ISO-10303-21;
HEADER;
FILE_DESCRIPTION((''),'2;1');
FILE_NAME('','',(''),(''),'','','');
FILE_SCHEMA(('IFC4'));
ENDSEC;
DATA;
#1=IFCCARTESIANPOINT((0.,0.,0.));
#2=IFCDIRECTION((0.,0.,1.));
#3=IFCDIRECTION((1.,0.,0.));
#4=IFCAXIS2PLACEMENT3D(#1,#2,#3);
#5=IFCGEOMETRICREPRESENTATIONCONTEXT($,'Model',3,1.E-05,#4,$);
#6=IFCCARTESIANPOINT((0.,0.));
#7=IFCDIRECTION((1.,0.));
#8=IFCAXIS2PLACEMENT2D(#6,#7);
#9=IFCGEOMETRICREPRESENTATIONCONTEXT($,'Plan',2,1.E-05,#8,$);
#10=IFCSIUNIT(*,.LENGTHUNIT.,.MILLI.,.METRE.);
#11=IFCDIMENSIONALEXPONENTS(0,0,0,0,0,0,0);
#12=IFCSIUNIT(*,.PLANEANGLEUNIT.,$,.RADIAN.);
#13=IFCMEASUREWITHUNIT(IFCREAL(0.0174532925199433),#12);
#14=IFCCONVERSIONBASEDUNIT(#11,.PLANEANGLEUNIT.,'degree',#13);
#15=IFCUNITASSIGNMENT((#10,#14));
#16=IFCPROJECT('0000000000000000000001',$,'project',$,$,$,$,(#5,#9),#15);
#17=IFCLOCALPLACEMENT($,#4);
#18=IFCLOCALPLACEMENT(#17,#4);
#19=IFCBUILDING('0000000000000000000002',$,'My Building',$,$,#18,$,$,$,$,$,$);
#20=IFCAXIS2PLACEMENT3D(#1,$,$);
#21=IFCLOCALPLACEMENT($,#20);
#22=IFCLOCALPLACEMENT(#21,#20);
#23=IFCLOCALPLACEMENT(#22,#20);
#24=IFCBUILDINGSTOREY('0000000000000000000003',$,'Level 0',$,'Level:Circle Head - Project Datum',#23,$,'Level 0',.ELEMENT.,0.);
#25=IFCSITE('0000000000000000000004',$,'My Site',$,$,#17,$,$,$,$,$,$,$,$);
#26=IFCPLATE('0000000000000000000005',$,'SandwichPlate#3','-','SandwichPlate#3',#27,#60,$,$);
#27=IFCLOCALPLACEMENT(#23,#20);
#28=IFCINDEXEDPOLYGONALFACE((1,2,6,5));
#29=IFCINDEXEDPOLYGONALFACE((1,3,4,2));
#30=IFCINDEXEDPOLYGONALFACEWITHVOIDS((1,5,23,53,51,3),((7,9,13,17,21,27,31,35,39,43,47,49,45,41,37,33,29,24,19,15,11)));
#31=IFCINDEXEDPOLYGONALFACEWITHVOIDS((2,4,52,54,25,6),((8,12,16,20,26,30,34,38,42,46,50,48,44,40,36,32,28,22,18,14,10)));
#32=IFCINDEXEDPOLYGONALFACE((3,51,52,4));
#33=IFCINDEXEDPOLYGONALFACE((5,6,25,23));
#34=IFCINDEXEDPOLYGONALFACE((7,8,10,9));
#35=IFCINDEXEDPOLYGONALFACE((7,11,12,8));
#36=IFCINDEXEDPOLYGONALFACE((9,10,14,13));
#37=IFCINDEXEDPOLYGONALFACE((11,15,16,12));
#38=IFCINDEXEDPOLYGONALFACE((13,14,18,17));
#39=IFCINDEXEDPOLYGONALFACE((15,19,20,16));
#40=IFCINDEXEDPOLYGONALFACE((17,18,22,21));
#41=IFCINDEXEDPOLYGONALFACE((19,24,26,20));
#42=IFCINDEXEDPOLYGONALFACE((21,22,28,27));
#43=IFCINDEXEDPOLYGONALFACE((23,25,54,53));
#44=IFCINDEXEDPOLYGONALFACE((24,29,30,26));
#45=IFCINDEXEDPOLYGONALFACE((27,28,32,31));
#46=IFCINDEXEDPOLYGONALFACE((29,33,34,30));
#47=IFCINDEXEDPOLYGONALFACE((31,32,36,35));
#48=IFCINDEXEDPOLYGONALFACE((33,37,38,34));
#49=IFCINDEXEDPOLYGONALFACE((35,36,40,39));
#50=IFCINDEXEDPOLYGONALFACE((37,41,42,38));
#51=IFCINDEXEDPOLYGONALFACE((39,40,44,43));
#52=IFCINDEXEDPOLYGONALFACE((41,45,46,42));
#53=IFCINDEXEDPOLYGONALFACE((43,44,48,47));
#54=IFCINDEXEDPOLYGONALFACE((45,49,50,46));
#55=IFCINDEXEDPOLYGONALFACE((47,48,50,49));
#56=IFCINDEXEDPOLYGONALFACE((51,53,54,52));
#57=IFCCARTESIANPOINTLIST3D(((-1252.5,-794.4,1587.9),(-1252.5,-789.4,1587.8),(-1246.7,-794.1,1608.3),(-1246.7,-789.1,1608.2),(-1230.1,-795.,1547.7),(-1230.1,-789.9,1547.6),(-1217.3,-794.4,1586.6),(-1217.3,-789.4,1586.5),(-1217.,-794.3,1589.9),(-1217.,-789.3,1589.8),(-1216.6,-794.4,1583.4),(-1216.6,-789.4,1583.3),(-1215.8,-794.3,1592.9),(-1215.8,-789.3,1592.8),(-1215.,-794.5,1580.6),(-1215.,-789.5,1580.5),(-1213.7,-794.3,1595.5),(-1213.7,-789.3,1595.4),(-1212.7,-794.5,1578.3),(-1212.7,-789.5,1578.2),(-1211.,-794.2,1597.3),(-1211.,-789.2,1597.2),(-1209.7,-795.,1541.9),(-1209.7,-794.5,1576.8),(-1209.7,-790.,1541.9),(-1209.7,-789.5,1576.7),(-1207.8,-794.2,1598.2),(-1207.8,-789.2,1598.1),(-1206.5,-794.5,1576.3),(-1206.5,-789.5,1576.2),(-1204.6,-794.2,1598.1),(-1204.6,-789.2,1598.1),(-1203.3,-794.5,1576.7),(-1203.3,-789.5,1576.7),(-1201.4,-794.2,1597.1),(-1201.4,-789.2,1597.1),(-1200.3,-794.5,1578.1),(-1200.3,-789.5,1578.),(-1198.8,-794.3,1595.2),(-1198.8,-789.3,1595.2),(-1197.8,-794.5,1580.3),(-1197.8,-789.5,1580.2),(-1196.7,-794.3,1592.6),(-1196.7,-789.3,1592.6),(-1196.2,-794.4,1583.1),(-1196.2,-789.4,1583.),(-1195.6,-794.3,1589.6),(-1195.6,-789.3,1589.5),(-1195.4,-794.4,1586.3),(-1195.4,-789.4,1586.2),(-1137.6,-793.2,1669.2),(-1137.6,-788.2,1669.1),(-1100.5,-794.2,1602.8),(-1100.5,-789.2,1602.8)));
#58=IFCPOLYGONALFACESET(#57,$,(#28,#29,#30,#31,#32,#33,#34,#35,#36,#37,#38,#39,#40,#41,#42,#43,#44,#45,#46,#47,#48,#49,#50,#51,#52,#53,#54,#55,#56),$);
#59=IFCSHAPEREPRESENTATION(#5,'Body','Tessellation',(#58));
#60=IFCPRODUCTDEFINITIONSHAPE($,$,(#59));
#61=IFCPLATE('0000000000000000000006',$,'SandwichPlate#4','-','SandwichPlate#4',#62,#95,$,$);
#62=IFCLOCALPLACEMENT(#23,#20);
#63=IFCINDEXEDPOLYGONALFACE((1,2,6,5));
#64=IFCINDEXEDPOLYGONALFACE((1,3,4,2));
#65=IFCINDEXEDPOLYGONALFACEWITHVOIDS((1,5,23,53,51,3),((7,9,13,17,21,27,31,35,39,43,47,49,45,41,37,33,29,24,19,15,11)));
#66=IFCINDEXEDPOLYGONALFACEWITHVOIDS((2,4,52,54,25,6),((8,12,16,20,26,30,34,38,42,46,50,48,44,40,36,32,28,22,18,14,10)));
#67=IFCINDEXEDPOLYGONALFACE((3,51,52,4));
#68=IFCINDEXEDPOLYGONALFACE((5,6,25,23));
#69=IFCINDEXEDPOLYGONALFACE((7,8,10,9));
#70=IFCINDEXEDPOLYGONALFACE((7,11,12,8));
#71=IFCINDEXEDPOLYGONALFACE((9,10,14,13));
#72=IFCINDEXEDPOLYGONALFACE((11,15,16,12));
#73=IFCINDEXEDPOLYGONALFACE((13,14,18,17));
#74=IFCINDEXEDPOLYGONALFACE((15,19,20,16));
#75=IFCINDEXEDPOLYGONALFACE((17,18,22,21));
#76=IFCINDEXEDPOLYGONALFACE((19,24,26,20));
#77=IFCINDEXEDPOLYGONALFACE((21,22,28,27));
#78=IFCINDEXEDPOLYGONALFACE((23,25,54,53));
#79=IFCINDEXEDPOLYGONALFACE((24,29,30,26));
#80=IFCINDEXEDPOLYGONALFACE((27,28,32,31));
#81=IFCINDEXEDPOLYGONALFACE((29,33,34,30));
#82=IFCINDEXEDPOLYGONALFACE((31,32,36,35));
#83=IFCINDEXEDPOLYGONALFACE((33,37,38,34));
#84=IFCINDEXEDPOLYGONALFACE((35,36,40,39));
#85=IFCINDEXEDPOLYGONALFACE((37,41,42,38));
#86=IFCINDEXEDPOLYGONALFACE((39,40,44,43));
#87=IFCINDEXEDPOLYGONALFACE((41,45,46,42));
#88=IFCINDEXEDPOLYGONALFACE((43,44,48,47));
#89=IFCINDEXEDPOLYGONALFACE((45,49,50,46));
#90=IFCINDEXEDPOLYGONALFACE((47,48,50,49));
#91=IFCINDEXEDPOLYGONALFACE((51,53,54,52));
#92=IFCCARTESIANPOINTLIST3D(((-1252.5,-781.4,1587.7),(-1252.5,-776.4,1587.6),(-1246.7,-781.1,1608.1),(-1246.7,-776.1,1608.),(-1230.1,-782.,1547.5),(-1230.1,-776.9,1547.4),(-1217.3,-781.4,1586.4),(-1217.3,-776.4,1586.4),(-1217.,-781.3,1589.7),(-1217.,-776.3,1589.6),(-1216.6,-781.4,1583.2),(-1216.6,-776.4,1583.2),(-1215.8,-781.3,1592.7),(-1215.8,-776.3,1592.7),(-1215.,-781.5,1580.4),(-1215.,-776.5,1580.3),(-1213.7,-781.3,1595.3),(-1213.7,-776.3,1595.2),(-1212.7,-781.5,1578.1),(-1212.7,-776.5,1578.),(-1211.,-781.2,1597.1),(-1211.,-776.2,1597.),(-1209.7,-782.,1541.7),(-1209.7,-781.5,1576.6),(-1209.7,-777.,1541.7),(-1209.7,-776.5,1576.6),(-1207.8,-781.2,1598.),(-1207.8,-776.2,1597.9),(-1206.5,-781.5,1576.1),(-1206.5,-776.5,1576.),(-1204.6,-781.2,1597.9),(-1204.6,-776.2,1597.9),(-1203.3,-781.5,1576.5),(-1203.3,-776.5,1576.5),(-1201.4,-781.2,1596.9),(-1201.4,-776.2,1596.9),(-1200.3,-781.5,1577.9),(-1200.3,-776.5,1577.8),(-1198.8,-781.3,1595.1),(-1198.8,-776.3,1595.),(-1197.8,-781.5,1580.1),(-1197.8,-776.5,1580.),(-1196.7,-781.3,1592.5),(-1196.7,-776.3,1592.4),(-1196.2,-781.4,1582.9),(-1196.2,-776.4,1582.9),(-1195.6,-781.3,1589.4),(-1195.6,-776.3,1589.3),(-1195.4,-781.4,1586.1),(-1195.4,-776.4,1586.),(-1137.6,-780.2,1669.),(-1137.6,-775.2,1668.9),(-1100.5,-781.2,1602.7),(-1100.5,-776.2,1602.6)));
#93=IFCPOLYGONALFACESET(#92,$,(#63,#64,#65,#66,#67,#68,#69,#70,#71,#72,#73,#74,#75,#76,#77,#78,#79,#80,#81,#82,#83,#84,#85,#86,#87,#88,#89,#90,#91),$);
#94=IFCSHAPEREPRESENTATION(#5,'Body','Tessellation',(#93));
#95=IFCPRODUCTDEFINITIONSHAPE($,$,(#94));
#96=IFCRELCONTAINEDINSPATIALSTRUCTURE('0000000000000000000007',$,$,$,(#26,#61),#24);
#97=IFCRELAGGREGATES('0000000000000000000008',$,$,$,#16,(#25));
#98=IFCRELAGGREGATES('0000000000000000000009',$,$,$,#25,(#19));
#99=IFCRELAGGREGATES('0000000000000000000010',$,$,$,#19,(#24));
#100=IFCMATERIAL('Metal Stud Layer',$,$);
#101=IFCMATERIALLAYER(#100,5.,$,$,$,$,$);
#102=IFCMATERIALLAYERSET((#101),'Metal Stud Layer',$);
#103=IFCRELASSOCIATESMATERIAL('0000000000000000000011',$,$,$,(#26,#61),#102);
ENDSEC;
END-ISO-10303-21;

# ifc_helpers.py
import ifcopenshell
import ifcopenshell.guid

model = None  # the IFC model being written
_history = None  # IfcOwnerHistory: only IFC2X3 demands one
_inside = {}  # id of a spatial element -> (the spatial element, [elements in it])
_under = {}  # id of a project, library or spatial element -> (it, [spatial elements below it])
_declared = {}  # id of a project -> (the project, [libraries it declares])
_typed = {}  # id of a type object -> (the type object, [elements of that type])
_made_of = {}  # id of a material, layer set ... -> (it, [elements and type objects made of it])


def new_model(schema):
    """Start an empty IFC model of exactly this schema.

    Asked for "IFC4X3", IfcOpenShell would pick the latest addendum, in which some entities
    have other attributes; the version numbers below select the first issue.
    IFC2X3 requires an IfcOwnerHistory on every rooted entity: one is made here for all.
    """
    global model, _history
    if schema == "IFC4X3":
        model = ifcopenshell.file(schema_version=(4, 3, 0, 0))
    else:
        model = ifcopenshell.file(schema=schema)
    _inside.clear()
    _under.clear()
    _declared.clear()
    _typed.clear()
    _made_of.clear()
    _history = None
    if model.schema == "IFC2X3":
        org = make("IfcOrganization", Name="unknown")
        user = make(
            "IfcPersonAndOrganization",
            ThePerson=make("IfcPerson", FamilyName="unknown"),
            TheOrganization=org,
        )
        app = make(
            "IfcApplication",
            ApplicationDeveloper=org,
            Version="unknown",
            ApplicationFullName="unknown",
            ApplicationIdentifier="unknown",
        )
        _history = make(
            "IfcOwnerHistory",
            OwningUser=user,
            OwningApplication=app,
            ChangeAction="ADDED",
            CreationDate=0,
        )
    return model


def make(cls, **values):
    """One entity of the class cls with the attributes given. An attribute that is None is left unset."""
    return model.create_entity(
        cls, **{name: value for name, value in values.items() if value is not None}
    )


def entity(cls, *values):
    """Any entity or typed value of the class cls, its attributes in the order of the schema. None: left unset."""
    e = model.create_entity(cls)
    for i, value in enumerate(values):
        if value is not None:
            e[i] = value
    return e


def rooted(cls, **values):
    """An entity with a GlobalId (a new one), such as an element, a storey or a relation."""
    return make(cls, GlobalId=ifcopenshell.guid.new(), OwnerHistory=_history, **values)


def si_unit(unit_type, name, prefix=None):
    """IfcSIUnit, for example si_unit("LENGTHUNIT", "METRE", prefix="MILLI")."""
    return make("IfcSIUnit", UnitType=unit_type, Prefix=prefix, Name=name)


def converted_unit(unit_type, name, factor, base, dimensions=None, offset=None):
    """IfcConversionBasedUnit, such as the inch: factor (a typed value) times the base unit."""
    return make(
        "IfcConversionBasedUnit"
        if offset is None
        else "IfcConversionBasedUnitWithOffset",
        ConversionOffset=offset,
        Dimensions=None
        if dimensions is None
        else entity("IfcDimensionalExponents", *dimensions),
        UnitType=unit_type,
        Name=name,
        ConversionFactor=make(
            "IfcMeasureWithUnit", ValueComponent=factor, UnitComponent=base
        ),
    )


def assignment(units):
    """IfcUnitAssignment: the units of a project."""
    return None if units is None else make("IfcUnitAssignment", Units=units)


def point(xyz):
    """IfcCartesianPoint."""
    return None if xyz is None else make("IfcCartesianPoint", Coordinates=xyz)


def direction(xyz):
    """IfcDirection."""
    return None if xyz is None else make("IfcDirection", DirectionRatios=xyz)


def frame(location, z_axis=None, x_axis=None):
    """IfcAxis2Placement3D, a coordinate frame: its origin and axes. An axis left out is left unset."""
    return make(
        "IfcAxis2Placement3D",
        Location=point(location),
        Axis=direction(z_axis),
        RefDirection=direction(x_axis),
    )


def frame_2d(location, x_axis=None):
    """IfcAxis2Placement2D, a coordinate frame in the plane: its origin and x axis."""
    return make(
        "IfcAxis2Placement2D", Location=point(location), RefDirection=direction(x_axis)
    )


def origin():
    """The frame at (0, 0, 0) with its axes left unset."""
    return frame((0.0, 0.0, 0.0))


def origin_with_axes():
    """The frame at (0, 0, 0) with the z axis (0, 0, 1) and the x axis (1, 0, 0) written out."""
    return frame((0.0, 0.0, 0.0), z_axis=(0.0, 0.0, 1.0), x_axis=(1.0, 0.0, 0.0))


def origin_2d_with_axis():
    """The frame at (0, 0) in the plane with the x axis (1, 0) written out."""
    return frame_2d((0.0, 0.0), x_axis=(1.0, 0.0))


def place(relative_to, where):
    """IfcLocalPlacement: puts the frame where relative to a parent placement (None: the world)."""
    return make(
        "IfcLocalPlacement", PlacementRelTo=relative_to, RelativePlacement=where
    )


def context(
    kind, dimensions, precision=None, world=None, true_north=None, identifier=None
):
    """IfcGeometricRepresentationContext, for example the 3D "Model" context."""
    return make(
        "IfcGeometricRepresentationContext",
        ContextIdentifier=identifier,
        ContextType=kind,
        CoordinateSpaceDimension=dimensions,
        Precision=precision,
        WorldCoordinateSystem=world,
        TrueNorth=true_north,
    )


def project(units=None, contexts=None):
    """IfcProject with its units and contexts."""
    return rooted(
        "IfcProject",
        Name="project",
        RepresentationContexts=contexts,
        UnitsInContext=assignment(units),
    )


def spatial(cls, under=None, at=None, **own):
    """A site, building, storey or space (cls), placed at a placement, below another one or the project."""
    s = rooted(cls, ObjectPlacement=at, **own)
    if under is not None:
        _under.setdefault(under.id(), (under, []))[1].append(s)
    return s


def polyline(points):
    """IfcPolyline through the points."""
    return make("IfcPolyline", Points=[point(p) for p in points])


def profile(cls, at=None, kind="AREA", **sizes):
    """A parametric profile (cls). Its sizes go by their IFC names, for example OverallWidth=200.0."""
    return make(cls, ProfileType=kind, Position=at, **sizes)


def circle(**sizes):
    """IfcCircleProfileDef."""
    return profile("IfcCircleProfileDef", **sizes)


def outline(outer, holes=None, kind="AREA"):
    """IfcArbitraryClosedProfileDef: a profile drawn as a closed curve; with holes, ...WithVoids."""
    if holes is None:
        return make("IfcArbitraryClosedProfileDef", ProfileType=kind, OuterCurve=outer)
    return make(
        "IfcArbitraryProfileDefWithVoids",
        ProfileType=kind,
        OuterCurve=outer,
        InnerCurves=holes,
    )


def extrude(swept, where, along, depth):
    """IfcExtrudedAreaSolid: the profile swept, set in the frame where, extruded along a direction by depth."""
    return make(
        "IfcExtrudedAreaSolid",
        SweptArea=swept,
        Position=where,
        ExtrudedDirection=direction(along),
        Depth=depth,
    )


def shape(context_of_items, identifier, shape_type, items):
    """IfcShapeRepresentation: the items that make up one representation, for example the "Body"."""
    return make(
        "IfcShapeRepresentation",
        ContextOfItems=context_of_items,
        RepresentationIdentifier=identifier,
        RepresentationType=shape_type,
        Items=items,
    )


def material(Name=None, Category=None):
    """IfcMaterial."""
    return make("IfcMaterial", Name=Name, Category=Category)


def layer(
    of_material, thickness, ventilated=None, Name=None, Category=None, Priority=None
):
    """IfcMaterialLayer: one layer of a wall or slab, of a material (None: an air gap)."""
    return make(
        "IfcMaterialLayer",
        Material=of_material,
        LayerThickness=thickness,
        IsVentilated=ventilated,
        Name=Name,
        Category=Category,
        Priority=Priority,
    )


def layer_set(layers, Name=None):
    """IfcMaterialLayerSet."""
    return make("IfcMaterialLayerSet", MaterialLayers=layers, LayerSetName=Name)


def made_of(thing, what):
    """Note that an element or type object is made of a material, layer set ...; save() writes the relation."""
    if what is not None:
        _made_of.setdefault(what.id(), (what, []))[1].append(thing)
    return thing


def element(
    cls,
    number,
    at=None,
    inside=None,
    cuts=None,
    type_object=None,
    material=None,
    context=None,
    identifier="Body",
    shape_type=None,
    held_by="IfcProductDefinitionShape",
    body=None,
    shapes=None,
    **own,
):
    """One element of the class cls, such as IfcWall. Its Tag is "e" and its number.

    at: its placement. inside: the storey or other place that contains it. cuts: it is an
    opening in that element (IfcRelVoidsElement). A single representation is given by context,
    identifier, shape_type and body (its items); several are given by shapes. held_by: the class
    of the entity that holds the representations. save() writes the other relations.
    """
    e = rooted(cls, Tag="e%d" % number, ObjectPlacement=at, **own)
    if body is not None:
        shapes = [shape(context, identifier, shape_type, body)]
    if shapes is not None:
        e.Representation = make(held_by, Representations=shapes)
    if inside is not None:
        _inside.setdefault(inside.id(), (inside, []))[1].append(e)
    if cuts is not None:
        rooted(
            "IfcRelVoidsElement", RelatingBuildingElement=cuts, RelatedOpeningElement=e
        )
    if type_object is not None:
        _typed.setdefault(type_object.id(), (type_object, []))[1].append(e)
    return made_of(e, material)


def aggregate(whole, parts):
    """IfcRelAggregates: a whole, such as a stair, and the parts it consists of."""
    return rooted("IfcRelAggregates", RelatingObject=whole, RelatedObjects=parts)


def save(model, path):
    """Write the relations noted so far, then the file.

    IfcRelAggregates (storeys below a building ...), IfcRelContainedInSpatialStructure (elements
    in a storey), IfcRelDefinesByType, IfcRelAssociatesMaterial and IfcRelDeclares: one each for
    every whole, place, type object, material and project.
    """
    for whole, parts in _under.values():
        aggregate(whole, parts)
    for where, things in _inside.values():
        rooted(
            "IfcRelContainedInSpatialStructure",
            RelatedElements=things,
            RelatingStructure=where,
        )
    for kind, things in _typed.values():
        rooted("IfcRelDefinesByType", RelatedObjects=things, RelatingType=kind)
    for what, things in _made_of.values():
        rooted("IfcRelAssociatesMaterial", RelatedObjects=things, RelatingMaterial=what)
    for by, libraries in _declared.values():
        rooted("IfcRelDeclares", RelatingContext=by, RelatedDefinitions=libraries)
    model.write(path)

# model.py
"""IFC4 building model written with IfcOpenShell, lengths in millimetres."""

from ifc_helpers import new_model, entity, si_unit, converted_unit, frame, origin, origin_with_axes, origin_2d_with_axis, place, context, project, spatial, polyline, circle, outline, extrude, material, layer, layer_set, element, save


model = new_model("IFC4")

# Units and contexts
model_context = context("Model", 3, precision=1e-05, world=origin_with_axes())
plan_context = context("Plan", 2, precision=1e-05, world=origin_2d_with_axis())
ifc_project = project(units=[si_unit("LENGTHUNIT", "METRE", prefix="MILLI"), converted_unit("PLANEANGLEUNIT", "degree", entity("IfcReal", 0.0174532925199433), si_unit("PLANEANGLEUNIT", "RADIAN"), dimensions=[0, 0, 0, 0, 0, 0, 0])], contexts=[model_context, plan_context])

# Site, building, storey
site_placement = place(None, origin_with_axes())
site = spatial("IfcSite", under=ifc_project, at=site_placement, Name="My Site")
building_placement = place(site_placement, origin_with_axes())
building = spatial("IfcBuilding", under=site, at=building_placement, Name="My Building")
placement_1 = place(None, origin())
placement_2 = place(placement_1, origin())
storey_placement = place(placement_2, origin())
storey = spatial("IfcBuildingStorey", under=building, at=storey_placement, Name="Level 0", ObjectType="Level:Circle Head - Project Datum", LongName="Level 0", CompositionType="ELEMENT", Elevation=0.0)

# Plates, openings
ifc_material_1 = material(Name="Metal Stud Layer")
ifc_layer_1 = layer(ifc_material_1, 5.0)
ifc_layer_set_1 = layer_set([ifc_layer_1], Name="Metal Stud Layer")
plate_1_placement = place(storey_placement, frame((-1222.8, -795.1, 1534.6), z_axis=(0.0, 0.999896, -0.014432), x_axis=(-0.487405, 0.012602, 0.873085)))
plate_1 = element("IfcPlate", 1, at=plate_1_placement, inside=storey, material=ifc_layer_set_1, Name="SandwichPlate#3", Description="-", ObjectType="SandwichPlate#3", context=model_context, shape_type="SweptSolid", body=[
    extrude(outline(polyline([(0.0, 0.0), (76.0, 0.0), (76.0, 140.0), (0.0, 140.0), (0.0, 0.0)])), origin_with_axes(), (0.0, 0.0, 1.0), 5.0),
])
opening_1_placement = place(plate_1_placement, frame((0.0, 0.0, 0.0), z_axis=(0.0, 0.0, 1.0), x_axis=(1.0, 0.0, 0.0)))
element("IfcOpeningElement", 2, at=opening_1_placement, cuts=plate_1, ObjectType="Opening", context=model_context, shape_type="SweptSolid", body=[
    extrude(outline(polyline([(76.0, 0.0), (76.0, 15.0), (61.0, 0.0), (76.0, 0.0)])), origin(), (0.0, 0.0, 1.0), 5.0),
])
opening_2_placement = place(plate_1_placement, frame((38.0, 40.0, -0.5), z_axis=(0.0, 0.0, 1.0), x_axis=(0.0, 1.0, 0.0)))
element("IfcOpeningElement", 3, at=opening_2_placement, cuts=plate_1, ObjectType="Opening", context=model_context, shape_type="SweptSolid", body=[
    extrude(circle(Radius=11.0, at=origin_2d_with_axis()), origin(), (0.0, 0.0, 1.0), 6.0),
])
opening_3_placement = place(plate_1_placement, frame((0.0, 0.0, 0.0), z_axis=(0.0, 0.0, 1.0), x_axis=(1.0, 0.0, 0.0)))
element("IfcOpeningElement", 4, at=opening_3_placement, cuts=plate_1, ObjectType="Opening", context=model_context, shape_type="SweptSolid", body=[
    extrude(outline(polyline([(0.0, 0.0), (15.0, 0.0), (0.0, 15.0), (0.0, 0.0)])), origin(), (0.0, 0.0, 1.0), 5.0),
])
plate_2_placement = place(storey_placement, frame((-1222.8, -782.1, 1534.4), z_axis=(0.0, 0.999896, -0.014432), x_axis=(-0.487405, 0.012602, 0.873085)))
plate_2 = element("IfcPlate", 5, at=plate_2_placement, inside=storey, material=ifc_layer_set_1, Name="SandwichPlate#4", Description="-", ObjectType="SandwichPlate#4", context=model_context, shape_type="SweptSolid", body=[
    extrude(outline(polyline([(0.0, 0.0), (76.0, 0.0), (76.0, 140.0), (0.0, 140.0), (0.0, 0.0)])), origin_with_axes(), (0.0, 0.0, 1.0), 5.0),
])
opening_4_placement = place(plate_2_placement, frame((0.0, 0.0, 0.0), z_axis=(0.0, 0.0, 1.0), x_axis=(1.0, 0.0, 0.0)))
element("IfcOpeningElement", 6, at=opening_4_placement, cuts=plate_2, ObjectType="Opening", context=model_context, shape_type="SweptSolid", body=[
    extrude(outline(polyline([(76.0, 0.0), (76.0, 15.0), (61.0, 0.0), (76.0, 0.0)])), origin(), (0.0, 0.0, 1.0), 5.0),
])
opening_5_placement = place(plate_2_placement, frame((38.0, 40.0, -0.5), z_axis=(0.0, 0.0, 1.0), x_axis=(0.0, 1.0, 0.0)))
element("IfcOpeningElement", 7, at=opening_5_placement, cuts=plate_2, ObjectType="Opening", context=model_context, shape_type="SweptSolid", body=[
    extrude(circle(Radius=11.0, at=origin_2d_with_axis()), origin(), (0.0, 0.0, 1.0), 6.0),
])
opening_6_placement = place(plate_2_placement, frame((0.0, 0.0, 0.0), z_axis=(0.0, 0.0, 1.0), x_axis=(1.0, 0.0, 0.0)))
element("IfcOpeningElement", 8, at=opening_6_placement, cuts=plate_2, ObjectType="Opening", context=model_context, shape_type="SweptSolid", body=[
    extrude(outline(polyline([(0.0, 0.0), (15.0, 0.0), (0.0, 15.0), (0.0, 0.0)])), origin(), (0.0, 0.0, 1.0), 5.0),
])

save(model, "model.ifc")
